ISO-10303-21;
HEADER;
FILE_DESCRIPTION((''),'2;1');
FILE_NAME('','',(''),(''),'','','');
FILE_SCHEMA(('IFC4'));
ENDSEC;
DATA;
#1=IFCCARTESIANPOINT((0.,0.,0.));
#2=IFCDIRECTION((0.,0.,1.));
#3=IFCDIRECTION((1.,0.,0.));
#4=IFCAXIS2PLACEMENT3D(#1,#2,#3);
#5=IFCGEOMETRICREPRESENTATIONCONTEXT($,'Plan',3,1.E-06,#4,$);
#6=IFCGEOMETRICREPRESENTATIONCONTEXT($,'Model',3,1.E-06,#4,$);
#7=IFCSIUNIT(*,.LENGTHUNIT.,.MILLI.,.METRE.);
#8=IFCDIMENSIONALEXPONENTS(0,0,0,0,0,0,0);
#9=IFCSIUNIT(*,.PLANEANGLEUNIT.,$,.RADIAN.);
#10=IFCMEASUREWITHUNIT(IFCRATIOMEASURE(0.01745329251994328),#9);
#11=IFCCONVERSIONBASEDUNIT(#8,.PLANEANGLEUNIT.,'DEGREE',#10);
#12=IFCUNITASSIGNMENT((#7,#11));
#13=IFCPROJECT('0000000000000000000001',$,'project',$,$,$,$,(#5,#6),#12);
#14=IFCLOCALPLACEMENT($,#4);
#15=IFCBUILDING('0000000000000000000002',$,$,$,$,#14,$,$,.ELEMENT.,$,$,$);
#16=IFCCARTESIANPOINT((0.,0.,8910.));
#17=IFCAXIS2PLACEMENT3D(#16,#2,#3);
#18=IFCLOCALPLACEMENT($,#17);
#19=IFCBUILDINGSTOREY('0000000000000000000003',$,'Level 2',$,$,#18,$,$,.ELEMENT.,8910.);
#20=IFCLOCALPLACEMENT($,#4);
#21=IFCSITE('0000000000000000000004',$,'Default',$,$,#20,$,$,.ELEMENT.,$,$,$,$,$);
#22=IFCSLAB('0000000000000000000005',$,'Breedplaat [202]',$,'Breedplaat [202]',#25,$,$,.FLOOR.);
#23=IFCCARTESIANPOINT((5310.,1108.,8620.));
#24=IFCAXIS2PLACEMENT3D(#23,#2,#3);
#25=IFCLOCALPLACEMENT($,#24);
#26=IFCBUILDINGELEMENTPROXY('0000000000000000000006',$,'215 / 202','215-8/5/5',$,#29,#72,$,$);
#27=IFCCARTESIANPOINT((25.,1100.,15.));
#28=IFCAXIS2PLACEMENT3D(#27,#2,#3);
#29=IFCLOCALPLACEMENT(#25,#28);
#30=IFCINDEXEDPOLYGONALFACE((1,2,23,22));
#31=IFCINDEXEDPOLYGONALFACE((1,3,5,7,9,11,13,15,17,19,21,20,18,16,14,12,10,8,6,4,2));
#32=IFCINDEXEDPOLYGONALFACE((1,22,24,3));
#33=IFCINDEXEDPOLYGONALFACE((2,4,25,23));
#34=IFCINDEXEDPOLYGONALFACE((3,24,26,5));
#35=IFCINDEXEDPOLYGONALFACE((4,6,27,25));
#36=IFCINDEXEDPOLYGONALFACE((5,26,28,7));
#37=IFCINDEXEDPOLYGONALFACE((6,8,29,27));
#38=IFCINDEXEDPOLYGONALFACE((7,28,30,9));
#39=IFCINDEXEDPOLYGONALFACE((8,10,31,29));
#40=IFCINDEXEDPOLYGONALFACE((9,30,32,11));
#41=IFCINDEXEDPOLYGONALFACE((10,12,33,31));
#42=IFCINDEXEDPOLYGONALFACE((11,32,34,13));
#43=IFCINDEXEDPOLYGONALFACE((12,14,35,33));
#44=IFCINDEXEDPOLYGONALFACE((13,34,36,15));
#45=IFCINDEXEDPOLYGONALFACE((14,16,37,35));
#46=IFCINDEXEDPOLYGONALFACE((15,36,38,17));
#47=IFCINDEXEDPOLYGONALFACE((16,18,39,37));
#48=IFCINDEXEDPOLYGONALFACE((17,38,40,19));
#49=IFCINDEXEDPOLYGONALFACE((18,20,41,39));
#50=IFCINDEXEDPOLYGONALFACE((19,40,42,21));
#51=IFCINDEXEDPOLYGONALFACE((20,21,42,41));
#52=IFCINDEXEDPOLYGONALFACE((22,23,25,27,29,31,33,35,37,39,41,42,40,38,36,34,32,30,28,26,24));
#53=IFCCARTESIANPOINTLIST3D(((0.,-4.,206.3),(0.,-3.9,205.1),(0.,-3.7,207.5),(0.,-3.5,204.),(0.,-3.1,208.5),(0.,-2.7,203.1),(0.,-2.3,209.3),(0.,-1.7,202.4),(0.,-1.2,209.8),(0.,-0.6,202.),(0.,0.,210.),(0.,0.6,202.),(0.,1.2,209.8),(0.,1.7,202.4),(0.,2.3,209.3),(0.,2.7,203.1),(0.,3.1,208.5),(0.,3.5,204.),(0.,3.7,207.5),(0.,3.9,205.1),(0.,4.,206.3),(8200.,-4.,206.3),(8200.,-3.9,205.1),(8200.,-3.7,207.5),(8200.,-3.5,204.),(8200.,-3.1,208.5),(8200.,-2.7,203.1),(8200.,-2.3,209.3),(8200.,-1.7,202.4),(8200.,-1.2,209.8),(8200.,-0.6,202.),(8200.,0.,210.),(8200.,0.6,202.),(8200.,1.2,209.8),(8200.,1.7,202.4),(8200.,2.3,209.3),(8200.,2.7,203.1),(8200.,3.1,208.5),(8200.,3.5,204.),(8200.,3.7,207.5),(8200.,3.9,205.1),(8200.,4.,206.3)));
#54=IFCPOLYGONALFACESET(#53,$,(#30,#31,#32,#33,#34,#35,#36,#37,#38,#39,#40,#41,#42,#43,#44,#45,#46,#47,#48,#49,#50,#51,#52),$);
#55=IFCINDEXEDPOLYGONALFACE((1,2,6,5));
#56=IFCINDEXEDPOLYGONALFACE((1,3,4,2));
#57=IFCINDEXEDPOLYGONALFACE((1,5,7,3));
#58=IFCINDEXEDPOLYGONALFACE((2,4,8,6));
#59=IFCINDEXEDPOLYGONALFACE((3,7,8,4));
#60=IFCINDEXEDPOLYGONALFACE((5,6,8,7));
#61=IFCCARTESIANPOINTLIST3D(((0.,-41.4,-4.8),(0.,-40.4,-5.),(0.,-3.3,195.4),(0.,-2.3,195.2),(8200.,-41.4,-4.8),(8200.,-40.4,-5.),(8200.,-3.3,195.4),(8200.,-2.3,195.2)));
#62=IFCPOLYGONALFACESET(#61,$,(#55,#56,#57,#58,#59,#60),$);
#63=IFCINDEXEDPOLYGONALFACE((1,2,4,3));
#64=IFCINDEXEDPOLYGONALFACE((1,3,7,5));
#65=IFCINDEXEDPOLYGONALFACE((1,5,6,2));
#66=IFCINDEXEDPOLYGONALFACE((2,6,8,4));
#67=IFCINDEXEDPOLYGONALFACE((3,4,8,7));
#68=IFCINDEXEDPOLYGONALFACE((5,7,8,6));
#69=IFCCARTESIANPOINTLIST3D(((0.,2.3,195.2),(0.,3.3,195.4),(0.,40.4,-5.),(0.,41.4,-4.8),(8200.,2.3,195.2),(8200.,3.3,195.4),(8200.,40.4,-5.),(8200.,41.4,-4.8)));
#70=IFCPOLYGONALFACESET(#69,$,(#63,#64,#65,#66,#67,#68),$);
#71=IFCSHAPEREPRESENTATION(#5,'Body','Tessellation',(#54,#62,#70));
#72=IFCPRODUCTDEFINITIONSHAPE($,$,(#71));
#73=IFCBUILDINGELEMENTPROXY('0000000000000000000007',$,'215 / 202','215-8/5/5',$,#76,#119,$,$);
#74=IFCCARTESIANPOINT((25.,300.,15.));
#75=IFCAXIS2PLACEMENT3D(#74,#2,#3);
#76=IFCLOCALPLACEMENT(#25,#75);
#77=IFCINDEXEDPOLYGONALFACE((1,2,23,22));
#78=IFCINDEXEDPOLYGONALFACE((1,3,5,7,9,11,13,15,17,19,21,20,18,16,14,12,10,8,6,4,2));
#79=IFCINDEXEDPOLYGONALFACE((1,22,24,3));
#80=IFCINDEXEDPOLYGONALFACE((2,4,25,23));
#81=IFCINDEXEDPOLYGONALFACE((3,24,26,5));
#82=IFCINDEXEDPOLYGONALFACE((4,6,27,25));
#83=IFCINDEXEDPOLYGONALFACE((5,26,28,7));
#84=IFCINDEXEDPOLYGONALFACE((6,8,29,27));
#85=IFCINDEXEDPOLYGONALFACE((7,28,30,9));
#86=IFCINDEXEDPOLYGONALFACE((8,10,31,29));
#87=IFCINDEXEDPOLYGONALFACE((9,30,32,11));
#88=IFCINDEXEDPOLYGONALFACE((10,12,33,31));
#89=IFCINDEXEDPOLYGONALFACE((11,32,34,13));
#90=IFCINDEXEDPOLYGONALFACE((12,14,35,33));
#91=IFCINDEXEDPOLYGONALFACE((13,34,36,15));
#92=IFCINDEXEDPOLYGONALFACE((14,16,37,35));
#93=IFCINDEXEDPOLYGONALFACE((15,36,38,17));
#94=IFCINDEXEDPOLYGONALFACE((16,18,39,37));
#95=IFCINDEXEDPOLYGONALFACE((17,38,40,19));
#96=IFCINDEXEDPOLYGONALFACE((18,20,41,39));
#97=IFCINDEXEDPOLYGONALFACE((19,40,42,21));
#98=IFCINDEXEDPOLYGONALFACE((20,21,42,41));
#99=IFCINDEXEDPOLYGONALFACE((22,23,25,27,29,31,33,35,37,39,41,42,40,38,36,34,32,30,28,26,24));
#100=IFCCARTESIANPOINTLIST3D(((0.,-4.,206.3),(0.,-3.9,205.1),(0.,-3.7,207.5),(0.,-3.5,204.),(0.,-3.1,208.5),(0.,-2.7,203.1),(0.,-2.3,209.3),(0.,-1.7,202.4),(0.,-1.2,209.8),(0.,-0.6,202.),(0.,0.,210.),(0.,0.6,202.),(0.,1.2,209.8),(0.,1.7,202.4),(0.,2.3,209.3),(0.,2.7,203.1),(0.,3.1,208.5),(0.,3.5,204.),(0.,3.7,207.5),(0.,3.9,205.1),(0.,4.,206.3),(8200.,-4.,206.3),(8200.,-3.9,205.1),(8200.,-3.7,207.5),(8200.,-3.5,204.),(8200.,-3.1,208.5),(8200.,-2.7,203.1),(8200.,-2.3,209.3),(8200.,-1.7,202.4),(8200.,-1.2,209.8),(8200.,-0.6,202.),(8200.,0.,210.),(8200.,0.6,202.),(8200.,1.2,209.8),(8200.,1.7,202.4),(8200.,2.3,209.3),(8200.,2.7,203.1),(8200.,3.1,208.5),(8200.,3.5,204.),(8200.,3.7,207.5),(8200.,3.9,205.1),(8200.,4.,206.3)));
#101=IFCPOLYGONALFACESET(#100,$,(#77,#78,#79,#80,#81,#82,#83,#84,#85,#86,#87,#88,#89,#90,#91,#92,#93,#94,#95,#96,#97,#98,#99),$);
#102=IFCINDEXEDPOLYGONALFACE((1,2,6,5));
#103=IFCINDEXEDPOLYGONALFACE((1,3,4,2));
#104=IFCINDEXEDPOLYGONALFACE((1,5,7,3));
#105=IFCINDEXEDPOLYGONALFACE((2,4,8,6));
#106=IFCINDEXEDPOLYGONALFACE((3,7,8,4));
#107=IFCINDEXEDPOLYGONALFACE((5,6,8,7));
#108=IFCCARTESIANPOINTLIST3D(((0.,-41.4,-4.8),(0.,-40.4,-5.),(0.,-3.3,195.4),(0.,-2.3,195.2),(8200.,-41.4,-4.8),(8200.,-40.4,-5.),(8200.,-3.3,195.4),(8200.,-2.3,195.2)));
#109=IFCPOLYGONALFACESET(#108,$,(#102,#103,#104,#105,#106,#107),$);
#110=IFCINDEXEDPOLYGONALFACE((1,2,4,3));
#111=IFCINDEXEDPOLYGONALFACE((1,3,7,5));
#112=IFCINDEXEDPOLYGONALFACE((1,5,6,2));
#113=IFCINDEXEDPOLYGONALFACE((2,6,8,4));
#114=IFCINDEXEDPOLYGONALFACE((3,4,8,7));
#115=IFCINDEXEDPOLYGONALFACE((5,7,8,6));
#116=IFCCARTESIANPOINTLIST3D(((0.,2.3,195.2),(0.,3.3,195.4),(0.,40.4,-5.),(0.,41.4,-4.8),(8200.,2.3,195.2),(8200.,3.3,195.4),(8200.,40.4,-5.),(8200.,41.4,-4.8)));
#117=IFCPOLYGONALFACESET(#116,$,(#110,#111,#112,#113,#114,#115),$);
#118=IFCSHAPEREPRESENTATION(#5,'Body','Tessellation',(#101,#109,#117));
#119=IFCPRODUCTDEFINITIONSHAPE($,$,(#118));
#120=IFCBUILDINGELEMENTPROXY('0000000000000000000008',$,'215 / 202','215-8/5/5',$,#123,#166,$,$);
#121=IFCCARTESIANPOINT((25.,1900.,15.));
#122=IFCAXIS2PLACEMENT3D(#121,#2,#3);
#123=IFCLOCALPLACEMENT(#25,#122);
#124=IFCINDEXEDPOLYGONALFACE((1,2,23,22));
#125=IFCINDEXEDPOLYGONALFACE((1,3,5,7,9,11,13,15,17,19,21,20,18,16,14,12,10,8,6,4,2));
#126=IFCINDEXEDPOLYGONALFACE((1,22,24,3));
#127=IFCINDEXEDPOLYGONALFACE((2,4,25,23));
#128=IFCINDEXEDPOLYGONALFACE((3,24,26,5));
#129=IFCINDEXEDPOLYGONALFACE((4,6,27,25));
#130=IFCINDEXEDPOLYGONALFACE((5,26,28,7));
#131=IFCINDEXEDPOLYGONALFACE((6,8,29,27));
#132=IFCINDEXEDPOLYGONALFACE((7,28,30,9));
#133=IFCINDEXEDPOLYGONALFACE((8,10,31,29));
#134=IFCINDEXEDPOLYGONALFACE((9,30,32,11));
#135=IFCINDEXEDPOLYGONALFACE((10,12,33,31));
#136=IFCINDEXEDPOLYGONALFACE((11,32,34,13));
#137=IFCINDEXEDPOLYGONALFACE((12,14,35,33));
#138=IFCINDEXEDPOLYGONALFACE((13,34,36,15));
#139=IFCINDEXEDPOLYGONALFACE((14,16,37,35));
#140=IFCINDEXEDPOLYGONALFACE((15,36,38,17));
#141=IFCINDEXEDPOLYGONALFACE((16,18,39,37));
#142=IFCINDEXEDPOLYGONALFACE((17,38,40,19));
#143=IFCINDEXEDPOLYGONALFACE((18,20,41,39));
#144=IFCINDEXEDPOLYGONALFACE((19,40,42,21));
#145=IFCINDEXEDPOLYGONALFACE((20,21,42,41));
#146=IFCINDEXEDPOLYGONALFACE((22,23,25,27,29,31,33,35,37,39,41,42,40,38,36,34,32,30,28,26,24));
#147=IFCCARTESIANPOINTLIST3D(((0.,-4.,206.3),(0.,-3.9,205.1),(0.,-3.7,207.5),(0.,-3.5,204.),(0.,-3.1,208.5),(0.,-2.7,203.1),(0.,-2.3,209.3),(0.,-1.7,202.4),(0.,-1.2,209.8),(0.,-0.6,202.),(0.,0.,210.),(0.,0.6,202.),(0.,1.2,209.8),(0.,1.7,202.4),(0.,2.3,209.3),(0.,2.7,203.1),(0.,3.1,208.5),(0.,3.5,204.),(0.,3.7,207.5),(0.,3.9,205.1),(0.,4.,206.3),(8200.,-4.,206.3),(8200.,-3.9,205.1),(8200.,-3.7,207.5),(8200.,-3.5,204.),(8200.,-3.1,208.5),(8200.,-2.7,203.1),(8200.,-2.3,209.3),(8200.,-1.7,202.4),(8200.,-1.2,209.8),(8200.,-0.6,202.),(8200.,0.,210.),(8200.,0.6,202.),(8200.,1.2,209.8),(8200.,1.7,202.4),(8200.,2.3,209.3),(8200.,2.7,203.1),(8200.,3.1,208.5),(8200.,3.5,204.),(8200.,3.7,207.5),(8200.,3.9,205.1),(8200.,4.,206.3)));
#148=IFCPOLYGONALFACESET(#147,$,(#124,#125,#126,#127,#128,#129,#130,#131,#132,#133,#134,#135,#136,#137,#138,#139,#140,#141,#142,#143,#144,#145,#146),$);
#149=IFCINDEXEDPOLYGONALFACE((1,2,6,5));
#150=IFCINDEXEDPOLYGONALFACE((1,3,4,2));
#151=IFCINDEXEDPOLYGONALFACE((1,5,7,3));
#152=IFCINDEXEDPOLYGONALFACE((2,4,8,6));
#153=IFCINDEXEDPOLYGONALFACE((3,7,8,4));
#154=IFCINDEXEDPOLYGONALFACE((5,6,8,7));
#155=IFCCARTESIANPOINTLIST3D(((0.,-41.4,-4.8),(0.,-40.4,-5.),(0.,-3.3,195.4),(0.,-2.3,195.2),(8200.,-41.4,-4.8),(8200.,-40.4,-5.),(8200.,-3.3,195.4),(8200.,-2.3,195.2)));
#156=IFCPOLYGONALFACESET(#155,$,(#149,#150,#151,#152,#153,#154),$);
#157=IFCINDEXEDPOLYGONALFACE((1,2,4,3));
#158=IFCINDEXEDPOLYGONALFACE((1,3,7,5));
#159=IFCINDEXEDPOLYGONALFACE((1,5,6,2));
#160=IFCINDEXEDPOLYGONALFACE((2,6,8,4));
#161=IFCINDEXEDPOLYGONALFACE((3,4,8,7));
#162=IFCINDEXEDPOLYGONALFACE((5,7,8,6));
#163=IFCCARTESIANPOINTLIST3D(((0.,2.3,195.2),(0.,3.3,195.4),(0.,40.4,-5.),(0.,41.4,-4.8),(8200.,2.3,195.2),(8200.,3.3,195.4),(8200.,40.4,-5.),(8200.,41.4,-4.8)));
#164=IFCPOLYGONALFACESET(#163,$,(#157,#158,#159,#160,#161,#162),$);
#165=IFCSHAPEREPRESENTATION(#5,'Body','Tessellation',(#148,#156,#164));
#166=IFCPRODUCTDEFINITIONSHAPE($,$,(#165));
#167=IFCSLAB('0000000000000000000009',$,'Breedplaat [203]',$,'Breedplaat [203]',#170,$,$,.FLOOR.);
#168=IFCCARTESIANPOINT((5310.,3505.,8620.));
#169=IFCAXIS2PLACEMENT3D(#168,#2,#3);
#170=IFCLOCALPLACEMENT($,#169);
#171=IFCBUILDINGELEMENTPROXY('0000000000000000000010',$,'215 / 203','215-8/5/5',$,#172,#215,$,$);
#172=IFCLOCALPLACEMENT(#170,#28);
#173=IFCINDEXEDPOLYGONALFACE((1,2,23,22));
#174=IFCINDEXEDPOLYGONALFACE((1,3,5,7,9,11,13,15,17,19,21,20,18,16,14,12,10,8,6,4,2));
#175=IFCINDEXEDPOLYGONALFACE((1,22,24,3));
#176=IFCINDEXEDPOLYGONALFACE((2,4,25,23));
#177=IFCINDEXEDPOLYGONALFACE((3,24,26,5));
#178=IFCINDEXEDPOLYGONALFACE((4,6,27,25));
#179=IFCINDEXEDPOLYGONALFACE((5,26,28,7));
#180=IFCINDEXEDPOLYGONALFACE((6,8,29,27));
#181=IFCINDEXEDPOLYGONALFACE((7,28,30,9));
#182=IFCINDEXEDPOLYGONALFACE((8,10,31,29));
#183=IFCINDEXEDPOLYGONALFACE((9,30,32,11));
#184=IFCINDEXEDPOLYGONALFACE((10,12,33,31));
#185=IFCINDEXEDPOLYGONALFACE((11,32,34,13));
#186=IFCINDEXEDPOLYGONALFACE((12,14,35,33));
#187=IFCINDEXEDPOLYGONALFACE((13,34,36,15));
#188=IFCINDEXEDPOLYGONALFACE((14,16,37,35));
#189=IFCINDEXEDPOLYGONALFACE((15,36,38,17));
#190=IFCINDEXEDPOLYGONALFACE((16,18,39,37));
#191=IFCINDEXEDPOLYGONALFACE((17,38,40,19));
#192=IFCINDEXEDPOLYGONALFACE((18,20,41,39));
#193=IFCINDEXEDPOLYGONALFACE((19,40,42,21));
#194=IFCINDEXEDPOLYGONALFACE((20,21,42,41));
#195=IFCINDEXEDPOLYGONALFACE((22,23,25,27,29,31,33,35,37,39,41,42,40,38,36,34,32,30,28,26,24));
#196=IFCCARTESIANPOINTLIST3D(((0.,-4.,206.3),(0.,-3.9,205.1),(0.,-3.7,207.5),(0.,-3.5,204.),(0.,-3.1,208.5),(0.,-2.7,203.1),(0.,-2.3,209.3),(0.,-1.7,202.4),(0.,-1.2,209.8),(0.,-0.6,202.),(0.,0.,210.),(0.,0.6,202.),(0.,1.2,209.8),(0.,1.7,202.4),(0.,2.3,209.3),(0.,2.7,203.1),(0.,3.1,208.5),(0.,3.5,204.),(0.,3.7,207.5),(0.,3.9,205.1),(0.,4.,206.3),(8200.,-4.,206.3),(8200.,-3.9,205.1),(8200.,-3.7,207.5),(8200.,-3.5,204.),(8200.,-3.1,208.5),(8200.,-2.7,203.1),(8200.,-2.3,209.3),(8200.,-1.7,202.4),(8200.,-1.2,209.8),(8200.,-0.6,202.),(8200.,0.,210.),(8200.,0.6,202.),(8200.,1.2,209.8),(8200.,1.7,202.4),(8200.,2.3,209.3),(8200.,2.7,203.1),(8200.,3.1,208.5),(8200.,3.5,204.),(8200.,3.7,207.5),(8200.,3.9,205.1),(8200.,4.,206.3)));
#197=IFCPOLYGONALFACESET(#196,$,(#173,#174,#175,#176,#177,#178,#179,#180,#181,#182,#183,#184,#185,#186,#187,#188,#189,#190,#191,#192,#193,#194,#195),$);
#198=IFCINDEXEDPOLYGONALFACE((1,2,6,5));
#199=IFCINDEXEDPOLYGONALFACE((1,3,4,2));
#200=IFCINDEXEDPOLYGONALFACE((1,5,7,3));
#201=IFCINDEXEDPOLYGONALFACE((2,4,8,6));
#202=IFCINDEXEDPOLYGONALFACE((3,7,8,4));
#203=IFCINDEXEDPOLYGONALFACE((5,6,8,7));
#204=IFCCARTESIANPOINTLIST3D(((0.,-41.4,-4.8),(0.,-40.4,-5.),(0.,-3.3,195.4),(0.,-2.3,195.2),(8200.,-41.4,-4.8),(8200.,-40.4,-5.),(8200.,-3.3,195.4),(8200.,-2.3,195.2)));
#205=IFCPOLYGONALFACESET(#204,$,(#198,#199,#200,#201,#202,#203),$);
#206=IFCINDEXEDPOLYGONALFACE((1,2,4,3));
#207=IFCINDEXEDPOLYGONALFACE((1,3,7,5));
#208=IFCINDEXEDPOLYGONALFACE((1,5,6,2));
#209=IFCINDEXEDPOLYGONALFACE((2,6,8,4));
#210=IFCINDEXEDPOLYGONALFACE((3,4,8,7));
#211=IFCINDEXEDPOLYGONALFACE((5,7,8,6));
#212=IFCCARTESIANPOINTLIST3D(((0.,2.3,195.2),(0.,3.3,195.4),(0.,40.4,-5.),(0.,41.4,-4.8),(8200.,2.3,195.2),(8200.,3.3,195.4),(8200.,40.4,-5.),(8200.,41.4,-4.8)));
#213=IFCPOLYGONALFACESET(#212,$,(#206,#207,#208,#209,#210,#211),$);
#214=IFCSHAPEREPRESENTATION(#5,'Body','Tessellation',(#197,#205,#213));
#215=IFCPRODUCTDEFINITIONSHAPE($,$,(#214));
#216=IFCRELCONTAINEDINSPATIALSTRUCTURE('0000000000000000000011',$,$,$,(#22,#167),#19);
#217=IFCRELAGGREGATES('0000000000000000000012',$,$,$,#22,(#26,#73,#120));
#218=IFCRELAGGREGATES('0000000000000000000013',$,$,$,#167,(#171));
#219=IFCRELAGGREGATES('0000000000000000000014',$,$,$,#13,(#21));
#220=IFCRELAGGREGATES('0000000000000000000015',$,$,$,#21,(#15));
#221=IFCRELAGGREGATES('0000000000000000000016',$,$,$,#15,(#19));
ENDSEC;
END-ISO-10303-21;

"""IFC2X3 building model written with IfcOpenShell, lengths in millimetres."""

from ifc_helpers import new_model, entity, si_unit, converted_unit, frame, origin_with_axes, origin_2d_with_axis, place, context, project, spatial, rectangle, circle, extrude, element, aggregate, save


model = new_model("IFC2X3")

# Units and contexts
plan_context = context("Plan", 3, precision=1e-06, world=origin_with_axes())
model_context = context("Model", 3, precision=1e-06, world=origin_with_axes())
ifc_project = project(units=[si_unit("LENGTHUNIT", "METRE", prefix="MILLI"), converted_unit("PLANEANGLEUNIT", "DEGREE", entity("IfcRatioMeasure", 0.01745329251994328), si_unit("PLANEANGLEUNIT", "RADIAN"), dimensions=[0, 0, 0, 0, 0, 0, 0])], contexts=[plan_context, model_context])

# Site, building, storey
site_placement = place(None, origin_with_axes())
site = spatial("IfcSite", under=ifc_project, at=site_placement, Name="Default", CompositionType="ELEMENT")
building_placement = place(None, origin_with_axes())
building = spatial("IfcBuilding", under=site, at=building_placement, CompositionType="ELEMENT")
storey_placement = place(None, frame((0.0, 0.0, 8910.0), z_axis=(0.0, 0.0, 1.0), x_axis=(1.0, 0.0, 0.0)))
storey = spatial("IfcBuildingStorey", under=building, at=storey_placement, Name="Level 2", CompositionType="ELEMENT", Elevation=8910.0)

# Slabs, building element proxies
slab_1_placement = place(None, frame((5310.0, 1108.0, 8620.0), z_axis=(0.0, 0.0, 1.0), x_axis=(1.0, 0.0, 0.0)))
slab_1 = element("IfcSlab", 1, at=slab_1_placement, inside=storey, Name="Breedplaat [202]", ObjectType="Breedplaat [202]", PredefinedType="FLOOR")
proxy_1_placement = place(slab_1_placement, frame((25.0, 1100.0, 15.0), z_axis=(0.0, 0.0, 1.0), x_axis=(1.0, 0.0, 0.0)))
proxy_1 = element("IfcBuildingElementProxy", 2, at=proxy_1_placement, Name="215 / 202", Description="215-8/5/5", context=plan_context, shape_type="SweptSolid", body=[
    extrude(circle(Radius=4.0, at=origin_2d_with_axis()), frame((0.0, 0.0, 206.0), z_axis=(1.0, 0.0, 0.0), x_axis=(0.0, 0.0, 1.0)), (0.0, 0.0, 1.0), 8200.0),
    extrude(rectangle(XDim=203.8, YDim=1.0, at=origin_2d_with_axis()), frame((0.0, -21.9, 95.2), z_axis=(1.0, 0.0, 0.0), x_axis=(0.0, 0.187112, 0.982339)), (0.0, 0.0, 1.0), 8200.0),
    extrude(rectangle(XDim=203.8, YDim=1.0, at=origin_2d_with_axis()), frame((0.0, 21.9, 95.2), z_axis=(1.0, 0.0, 0.0), x_axis=(0.0, -0.187112, 0.982339)), (0.0, 0.0, 1.0), 8200.0),
])
proxy_2_placement = place(slab_1_placement, frame((25.0, 300.0, 15.0), z_axis=(0.0, 0.0, 1.0), x_axis=(1.0, 0.0, 0.0)))
proxy_2 = element("IfcBuildingElementProxy", 3, at=proxy_2_placement, Name="215 / 202", Description="215-8/5/5", context=plan_context, shape_type="SweptSolid", body=[
    extrude(circle(Radius=4.0, at=origin_2d_with_axis()), frame((0.0, 0.0, 206.0), z_axis=(1.0, 0.0, 0.0), x_axis=(0.0, 0.0, 1.0)), (0.0, 0.0, 1.0), 8200.0),
    extrude(rectangle(XDim=203.8, YDim=1.0, at=origin_2d_with_axis()), frame((0.0, -21.9, 95.2), z_axis=(1.0, 0.0, 0.0), x_axis=(0.0, 0.187112, 0.982339)), (0.0, 0.0, 1.0), 8200.0),
    extrude(rectangle(XDim=203.8, YDim=1.0, at=origin_2d_with_axis()), frame((0.0, 21.9, 95.2), z_axis=(1.0, 0.0, 0.0), x_axis=(0.0, -0.187112, 0.982339)), (0.0, 0.0, 1.0), 8200.0),
])
proxy_3_placement = place(slab_1_placement, frame((25.0, 1900.0, 15.0), z_axis=(0.0, 0.0, 1.0), x_axis=(1.0, 0.0, 0.0)))
proxy_3 = element("IfcBuildingElementProxy", 4, at=proxy_3_placement, Name="215 / 202", Description="215-8/5/5", context=plan_context, shape_type="SweptSolid", body=[
    extrude(circle(Radius=4.0, at=origin_2d_with_axis()), frame((0.0, 0.0, 206.0), z_axis=(1.0, 0.0, 0.0), x_axis=(0.0, 0.0, 1.0)), (0.0, 0.0, 1.0), 8200.0),
    extrude(rectangle(XDim=203.8, YDim=1.0, at=origin_2d_with_axis()), frame((0.0, -21.9, 95.2), z_axis=(1.0, 0.0, 0.0), x_axis=(0.0, 0.187112, 0.982339)), (0.0, 0.0, 1.0), 8200.0),
    extrude(rectangle(XDim=203.8, YDim=1.0, at=origin_2d_with_axis()), frame((0.0, 21.9, 95.2), z_axis=(1.0, 0.0, 0.0), x_axis=(0.0, -0.187112, 0.982339)), (0.0, 0.0, 1.0), 8200.0),
])
aggregate(slab_1, [proxy_1, proxy_2, proxy_3])
slab_2_placement = place(None, frame((5310.0, 3505.0, 8620.0), z_axis=(0.0, 0.0, 1.0), x_axis=(1.0, 0.0, 0.0)))
slab_2 = element("IfcSlab", 5, at=slab_2_placement, inside=storey, Name="Breedplaat [203]", ObjectType="Breedplaat [203]", PredefinedType="FLOOR")
proxy_4_placement = place(slab_2_placement, frame((25.0, 1100.0, 15.0), z_axis=(0.0, 0.0, 1.0), x_axis=(1.0, 0.0, 0.0)))
proxy_4 = element("IfcBuildingElementProxy", 6, at=proxy_4_placement, Name="215 / 203", Description="215-8/5/5", context=plan_context, shape_type="SweptSolid", body=[
    extrude(circle(Radius=4.0, at=origin_2d_with_axis()), frame((0.0, 0.0, 206.0), z_axis=(1.0, 0.0, 0.0), x_axis=(0.0, 0.0, 1.0)), (0.0, 0.0, 1.0), 8200.0),
    extrude(rectangle(XDim=203.8, YDim=1.0, at=origin_2d_with_axis()), frame((0.0, -21.9, 95.2), z_axis=(1.0, 0.0, 0.0), x_axis=(0.0, 0.187112, 0.982339)), (0.0, 0.0, 1.0), 8200.0),
    extrude(rectangle(XDim=203.8, YDim=1.0, at=origin_2d_with_axis()), frame((0.0, 21.9, 95.2), z_axis=(1.0, 0.0, 0.0), x_axis=(0.0, -0.187112, 0.982339)), (0.0, 0.0, 1.0), 8200.0),
])
aggregate(slab_2, [proxy_4])

save(model, "model.ifc")
